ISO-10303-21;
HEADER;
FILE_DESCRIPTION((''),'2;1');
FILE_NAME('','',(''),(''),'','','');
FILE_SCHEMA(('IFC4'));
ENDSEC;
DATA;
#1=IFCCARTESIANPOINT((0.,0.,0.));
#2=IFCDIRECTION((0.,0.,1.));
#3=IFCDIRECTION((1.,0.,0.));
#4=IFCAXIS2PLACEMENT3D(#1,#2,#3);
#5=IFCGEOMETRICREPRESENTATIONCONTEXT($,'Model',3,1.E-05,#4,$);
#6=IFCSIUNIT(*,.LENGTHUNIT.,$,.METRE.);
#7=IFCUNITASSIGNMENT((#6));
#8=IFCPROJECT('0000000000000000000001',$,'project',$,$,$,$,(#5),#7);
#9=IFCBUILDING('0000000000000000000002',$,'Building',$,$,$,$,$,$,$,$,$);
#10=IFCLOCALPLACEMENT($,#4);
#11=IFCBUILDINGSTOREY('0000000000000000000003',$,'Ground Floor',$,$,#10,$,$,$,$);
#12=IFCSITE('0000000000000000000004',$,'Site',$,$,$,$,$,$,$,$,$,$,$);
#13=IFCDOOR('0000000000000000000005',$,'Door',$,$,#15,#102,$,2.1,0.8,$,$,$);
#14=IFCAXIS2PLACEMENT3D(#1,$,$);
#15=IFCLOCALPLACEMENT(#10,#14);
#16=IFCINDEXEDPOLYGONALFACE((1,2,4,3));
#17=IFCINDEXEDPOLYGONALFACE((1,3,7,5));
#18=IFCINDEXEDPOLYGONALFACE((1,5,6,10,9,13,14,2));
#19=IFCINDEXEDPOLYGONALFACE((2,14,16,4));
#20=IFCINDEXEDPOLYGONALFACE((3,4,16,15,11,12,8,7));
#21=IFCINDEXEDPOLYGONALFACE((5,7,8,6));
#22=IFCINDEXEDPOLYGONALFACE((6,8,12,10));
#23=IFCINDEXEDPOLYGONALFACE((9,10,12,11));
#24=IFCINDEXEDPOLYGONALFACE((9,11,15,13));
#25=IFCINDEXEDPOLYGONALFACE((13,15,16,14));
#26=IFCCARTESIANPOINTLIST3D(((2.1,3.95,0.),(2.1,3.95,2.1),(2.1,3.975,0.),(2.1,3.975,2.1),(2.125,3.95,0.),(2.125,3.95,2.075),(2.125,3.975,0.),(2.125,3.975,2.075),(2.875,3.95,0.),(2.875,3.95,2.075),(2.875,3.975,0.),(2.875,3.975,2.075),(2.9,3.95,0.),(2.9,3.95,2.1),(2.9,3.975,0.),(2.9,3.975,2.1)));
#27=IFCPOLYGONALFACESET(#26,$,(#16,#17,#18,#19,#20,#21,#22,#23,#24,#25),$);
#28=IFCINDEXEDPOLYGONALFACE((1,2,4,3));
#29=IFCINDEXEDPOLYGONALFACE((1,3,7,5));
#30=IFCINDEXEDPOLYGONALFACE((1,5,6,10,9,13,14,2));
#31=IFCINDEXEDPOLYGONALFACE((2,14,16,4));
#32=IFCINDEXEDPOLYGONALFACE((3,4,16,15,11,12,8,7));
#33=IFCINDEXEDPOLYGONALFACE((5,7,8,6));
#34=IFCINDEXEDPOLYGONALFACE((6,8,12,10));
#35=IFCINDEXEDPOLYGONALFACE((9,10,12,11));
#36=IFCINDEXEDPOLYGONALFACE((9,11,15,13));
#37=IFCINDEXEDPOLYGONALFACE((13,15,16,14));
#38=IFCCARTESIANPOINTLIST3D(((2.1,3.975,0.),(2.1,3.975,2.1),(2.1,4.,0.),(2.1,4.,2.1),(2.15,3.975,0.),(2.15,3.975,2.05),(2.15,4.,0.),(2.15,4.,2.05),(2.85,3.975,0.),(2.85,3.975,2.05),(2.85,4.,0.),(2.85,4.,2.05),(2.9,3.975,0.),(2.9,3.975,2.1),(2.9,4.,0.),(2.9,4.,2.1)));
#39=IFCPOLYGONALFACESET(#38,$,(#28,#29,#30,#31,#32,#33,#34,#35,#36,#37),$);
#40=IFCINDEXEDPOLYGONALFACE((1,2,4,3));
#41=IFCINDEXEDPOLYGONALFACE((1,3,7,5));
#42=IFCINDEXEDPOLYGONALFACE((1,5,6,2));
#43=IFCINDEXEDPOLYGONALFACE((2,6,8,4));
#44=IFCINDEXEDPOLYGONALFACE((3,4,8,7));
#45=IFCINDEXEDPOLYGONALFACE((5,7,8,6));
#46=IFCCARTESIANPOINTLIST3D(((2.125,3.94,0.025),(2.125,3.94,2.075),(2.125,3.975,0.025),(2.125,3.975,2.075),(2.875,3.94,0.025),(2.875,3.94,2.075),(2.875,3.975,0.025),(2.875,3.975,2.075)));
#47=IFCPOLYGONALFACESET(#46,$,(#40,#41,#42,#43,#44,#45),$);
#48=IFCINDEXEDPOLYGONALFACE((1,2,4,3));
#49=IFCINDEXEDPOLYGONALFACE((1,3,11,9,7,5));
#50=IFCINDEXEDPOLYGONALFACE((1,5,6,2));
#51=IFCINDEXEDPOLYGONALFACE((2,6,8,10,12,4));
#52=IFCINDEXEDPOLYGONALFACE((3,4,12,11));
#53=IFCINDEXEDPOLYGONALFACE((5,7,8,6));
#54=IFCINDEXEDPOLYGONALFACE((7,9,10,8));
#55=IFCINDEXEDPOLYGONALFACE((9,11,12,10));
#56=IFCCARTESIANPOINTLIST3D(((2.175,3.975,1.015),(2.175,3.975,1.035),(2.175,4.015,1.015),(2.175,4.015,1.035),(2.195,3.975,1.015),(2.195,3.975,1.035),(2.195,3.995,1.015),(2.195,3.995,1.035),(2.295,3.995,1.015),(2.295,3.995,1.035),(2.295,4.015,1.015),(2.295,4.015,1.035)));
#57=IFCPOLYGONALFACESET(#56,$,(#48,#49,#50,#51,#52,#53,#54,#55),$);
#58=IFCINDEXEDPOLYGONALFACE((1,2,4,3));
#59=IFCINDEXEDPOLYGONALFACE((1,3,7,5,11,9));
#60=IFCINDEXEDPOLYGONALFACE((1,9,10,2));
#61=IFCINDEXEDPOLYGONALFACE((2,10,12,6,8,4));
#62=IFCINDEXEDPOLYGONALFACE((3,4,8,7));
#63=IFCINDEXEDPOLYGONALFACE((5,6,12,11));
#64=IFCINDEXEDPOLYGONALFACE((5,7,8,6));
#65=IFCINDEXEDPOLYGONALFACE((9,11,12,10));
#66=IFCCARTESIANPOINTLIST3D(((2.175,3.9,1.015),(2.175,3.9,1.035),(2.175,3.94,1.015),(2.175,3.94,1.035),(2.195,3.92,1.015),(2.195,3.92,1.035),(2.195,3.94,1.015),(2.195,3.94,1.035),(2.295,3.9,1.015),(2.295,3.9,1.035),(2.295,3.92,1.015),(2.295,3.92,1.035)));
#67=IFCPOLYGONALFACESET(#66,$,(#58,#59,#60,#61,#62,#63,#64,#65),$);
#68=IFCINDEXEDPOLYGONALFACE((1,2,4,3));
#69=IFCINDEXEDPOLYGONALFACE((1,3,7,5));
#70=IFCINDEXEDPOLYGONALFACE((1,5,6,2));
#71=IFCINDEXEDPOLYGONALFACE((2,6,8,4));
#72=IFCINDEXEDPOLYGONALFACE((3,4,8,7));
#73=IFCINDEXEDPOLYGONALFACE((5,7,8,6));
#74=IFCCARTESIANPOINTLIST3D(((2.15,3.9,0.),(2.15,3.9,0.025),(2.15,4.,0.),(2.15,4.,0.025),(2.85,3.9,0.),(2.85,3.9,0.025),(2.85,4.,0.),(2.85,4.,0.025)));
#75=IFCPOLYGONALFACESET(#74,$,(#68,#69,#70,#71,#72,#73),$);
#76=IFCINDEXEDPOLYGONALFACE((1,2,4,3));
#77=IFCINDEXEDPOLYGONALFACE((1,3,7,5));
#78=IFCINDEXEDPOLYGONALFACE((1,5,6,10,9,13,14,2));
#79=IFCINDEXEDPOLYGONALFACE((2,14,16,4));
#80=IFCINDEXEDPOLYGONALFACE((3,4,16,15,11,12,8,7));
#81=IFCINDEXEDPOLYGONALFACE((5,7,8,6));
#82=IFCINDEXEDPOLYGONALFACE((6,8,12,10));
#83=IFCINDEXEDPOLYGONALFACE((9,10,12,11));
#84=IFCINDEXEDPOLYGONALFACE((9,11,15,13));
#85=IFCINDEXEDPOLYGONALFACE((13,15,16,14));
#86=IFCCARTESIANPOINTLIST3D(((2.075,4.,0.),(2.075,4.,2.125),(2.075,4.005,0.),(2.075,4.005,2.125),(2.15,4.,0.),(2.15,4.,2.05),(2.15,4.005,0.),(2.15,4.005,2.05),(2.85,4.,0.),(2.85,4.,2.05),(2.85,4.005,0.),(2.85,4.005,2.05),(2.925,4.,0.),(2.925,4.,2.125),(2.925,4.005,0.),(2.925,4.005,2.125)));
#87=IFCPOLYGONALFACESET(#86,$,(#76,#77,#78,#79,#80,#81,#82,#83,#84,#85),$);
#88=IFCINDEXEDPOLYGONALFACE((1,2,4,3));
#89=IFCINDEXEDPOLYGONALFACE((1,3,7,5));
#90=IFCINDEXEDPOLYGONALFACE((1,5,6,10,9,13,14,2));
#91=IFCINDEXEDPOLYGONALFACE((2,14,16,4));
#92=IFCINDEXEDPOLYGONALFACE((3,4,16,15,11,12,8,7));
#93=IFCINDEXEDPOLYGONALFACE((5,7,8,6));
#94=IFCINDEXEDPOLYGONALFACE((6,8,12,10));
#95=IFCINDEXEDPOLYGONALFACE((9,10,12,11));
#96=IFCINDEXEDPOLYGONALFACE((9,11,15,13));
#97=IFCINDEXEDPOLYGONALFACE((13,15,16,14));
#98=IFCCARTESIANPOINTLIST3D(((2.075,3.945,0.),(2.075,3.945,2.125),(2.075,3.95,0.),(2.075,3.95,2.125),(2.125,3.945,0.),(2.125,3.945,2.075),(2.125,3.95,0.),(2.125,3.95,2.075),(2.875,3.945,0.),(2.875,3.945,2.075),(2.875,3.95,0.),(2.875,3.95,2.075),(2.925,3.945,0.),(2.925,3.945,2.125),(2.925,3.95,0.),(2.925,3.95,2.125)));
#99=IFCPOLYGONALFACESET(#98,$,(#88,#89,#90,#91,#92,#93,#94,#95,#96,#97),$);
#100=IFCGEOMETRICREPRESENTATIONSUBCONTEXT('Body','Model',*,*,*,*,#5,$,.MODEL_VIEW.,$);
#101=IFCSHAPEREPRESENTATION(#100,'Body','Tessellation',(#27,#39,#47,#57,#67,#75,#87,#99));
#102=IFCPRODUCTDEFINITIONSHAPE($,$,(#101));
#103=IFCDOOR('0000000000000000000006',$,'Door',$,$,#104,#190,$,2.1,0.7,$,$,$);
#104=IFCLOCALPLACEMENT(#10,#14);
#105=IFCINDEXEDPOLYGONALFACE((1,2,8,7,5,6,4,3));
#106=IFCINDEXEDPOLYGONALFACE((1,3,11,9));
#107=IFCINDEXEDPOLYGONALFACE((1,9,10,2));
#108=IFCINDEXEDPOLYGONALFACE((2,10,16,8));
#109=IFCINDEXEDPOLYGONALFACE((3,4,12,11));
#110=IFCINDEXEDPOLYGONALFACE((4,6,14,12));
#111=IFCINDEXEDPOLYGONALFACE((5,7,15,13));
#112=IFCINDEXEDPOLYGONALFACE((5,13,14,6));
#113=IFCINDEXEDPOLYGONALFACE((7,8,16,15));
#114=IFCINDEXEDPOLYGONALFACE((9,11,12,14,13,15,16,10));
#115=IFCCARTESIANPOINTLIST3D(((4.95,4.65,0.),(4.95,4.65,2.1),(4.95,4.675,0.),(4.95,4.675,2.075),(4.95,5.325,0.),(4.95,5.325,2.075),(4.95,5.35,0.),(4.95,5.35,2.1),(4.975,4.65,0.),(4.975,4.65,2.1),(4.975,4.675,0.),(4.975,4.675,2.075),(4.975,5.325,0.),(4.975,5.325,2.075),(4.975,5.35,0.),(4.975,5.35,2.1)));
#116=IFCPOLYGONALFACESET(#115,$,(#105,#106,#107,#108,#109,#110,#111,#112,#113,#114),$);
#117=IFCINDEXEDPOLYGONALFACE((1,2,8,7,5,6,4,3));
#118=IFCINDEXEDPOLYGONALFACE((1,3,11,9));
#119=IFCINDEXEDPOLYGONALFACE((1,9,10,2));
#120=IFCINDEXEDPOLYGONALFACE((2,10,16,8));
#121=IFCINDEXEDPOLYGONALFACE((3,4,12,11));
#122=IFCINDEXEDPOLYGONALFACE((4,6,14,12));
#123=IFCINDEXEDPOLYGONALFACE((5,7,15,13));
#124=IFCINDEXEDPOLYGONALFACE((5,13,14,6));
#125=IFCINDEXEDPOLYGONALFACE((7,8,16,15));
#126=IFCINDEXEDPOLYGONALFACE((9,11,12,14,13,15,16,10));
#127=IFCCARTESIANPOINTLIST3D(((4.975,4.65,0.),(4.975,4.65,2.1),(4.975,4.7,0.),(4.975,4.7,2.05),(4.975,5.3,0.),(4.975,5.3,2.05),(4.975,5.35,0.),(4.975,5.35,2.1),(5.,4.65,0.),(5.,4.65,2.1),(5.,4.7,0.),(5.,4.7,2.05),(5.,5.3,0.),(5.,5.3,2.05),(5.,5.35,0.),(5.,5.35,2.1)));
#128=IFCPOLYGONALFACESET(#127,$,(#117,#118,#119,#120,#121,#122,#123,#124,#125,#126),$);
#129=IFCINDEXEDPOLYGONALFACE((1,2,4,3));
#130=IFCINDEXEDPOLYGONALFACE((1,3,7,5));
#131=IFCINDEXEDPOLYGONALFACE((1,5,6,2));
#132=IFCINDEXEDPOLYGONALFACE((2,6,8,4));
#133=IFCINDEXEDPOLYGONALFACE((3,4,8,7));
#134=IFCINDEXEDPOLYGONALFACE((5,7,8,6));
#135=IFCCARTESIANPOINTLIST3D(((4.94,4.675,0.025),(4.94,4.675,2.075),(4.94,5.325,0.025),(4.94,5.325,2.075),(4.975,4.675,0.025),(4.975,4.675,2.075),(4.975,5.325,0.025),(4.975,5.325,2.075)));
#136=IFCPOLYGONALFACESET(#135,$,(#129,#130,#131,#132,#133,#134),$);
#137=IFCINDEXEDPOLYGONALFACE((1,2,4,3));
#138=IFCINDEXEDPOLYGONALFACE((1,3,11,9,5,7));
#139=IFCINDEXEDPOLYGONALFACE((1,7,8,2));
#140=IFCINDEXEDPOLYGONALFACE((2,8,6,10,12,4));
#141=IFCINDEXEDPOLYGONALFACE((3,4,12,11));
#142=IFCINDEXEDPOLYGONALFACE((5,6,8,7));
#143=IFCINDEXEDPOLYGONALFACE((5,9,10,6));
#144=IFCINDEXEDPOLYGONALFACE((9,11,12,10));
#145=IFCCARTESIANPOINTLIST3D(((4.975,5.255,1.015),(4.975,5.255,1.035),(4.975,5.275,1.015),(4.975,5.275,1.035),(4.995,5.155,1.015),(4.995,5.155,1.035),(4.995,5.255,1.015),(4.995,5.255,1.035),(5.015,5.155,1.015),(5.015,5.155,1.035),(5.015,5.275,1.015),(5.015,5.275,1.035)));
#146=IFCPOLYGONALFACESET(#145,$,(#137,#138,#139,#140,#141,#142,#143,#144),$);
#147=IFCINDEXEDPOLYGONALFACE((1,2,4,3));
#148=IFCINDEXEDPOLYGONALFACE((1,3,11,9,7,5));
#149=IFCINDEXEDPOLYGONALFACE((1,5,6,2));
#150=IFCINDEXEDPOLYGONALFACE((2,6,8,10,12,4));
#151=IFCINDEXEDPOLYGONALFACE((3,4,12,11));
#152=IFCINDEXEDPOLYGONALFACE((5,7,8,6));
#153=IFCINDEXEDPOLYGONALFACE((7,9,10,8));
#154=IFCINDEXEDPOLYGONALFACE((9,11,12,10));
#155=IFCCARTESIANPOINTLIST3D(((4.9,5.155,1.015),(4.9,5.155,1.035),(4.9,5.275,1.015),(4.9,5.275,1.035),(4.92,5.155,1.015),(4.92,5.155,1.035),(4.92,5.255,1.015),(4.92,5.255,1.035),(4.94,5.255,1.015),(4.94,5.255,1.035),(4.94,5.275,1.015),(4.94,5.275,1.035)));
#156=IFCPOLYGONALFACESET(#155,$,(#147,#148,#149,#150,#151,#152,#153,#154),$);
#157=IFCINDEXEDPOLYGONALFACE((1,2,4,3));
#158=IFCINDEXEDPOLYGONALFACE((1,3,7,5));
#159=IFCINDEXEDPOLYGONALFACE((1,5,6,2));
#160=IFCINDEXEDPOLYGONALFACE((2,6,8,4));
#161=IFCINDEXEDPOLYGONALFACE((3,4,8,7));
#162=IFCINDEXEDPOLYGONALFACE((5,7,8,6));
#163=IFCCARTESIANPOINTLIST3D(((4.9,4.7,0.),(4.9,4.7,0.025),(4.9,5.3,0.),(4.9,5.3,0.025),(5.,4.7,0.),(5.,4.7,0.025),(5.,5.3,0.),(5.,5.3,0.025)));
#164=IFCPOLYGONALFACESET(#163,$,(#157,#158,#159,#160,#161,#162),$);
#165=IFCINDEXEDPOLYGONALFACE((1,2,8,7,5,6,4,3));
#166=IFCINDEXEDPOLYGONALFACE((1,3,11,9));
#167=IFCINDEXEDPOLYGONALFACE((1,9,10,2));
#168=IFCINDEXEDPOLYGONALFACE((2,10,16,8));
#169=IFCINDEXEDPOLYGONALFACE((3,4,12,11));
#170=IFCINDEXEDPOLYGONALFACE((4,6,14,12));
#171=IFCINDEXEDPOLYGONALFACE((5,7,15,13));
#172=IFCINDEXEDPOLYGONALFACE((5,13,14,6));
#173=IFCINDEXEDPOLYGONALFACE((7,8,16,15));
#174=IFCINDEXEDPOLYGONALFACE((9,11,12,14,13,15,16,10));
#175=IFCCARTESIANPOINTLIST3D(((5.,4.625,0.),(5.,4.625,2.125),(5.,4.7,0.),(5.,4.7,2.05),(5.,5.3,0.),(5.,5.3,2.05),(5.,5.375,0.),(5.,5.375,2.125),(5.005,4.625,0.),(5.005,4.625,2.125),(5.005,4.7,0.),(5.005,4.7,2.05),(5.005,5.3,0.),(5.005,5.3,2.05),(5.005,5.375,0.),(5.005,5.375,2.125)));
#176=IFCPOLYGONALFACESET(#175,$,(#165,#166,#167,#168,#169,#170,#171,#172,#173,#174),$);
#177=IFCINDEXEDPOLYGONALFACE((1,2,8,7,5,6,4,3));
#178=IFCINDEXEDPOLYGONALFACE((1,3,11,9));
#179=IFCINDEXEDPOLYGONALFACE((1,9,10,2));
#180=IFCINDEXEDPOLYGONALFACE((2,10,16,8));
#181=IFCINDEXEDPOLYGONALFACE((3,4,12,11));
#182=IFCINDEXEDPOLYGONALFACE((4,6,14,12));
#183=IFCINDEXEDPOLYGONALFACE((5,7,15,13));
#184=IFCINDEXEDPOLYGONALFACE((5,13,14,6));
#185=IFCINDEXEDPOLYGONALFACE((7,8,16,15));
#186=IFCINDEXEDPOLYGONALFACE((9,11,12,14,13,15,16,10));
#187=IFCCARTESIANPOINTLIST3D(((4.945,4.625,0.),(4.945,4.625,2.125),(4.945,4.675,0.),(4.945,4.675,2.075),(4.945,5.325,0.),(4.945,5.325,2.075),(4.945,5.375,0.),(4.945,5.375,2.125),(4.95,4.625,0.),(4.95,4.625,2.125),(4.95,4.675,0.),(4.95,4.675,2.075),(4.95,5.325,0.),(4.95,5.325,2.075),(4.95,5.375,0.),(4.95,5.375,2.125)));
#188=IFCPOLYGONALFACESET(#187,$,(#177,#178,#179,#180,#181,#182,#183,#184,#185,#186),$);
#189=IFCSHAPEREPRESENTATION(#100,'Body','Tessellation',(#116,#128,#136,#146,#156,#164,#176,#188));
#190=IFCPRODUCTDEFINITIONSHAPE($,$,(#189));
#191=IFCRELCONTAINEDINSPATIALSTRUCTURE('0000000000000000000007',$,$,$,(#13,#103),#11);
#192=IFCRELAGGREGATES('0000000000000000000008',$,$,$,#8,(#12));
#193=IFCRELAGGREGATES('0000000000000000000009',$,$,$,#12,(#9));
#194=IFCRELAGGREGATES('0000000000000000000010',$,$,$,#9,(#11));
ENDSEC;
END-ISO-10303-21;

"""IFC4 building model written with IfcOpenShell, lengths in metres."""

from ifc_helpers import new_model, si_unit, frame, origin_with_axes, place, context, subcontext, project, spatial, line, indexed_curve, outline, extrude, element, save


model = new_model("IFC4")

# Units and contexts
model_context = context("Model", 3, precision=1e-05, world=origin_with_axes())
body_context = subcontext(model_context, "Body", "Model", "MODEL_VIEW")
ifc_project = project(units=[si_unit("LENGTHUNIT", "METRE")], contexts=[model_context])

# Site, building, storey
site = spatial("IfcSite", under=ifc_project, Name="Site")
building = spatial("IfcBuilding", under=site, Name="Building")
storey_placement = place(None, origin_with_axes())
storey = spatial("IfcBuildingStorey", under=building, at=storey_placement, Name="Ground Floor")

# Doors
door_1_placement = place(storey_placement, frame((2.9, 4.0, 0.0), z_axis=(0.0, 0.0, 1.0), x_axis=(-1.0, 0.0, 0.0)))
element("IfcDoor", 1, at=door_1_placement, inside=storey, Name="Door", OverallHeight=2.1, OverallWidth=0.8, context=body_context, shape_type="SweptSolid", body=[
    extrude(outline(indexed_curve([(0.0, 0.0), (0.0, 2.1), (0.8, 2.1), (0.8, 0.0), (0.775, 0.0), (0.775, 2.075), (0.025, 2.075), (0.025, 0.0)], segments=[line(1, 2, 3, 4, 5, 6, 7, 8, 1)])), frame((0.0, 0.025, 0.0), z_axis=(0.0, -1.0, 0.0), x_axis=(1.0, 0.0, 0.0)), (0.0, 0.0, -1.0), 0.025),
    extrude(outline(indexed_curve([(0.0, 0.0), (0.0, 2.1), (0.8, 2.1), (0.8, 0.0), (0.75, 0.0), (0.75, 2.05), (0.05, 2.05), (0.05, 0.0)], segments=[line(1, 2, 3, 4, 5, 6, 7, 8, 1)])), frame((0.0, 0.0, 0.0), z_axis=(0.0, -1.0, 0.0), x_axis=(1.0, 0.0, 0.0)), (0.0, 0.0, -1.0), 0.025),
    extrude(outline(indexed_curve([(0.0, 0.0), (0.75, 0.0), (0.75, 0.035), (0.0, 0.035)], segments=[line(1, 2, 3, 4, 1)])), frame((0.025, 0.025, 0.025), z_axis=(0.0, 0.0, 1.0), x_axis=(1.0, 0.0, 0.0)), (0.0, 0.0, 1.0), 2.05),
    extrude(outline(indexed_curve([(0.0, 0.0), (0.0, -0.04), (-0.12, -0.04), (-0.12, -0.02), (-0.02, -0.02), (-0.02, 0.0)], segments=[line(1, 2, 3, 4, 5, 6, 1)])), frame((0.725, 0.025, 1.015), z_axis=(0.0, 0.0, 1.0), x_axis=(1.0, 0.0, 0.0)), (0.0, 0.0, 1.0), 0.02),
    extrude(outline(indexed_curve([(0.0, 0.0), (0.0, 0.04), (-0.12, 0.04), (-0.12, 0.02), (-0.02, 0.02), (-0.02, 0.0)], segments=[line(1, 2, 3, 4, 5, 6, 1)])), frame((0.725, 0.06, 1.015), z_axis=(0.0, 0.0, 1.0), x_axis=(1.0, 0.0, 0.0)), (0.0, 0.0, 1.0), 0.02),
    extrude(outline(indexed_curve([(0.0, 0.0), (0.7, 0.0), (0.7, 0.1), (0.0, 0.1)], segments=[line(1, 2, 3, 4, 1)])), frame((0.05, 0.0, 0.0), z_axis=(0.0, 0.0, 1.0), x_axis=(1.0, 0.0, 0.0)), (0.0, 0.0, 1.0), 0.025),
    extrude(outline(indexed_curve([(0.0, 0.0), (0.0, 2.125), (0.85, 2.125), (0.85, 0.0), (0.775, 0.0), (0.775, 2.05), (0.075, 2.05), (0.075, 0.0)], segments=[line(1, 2, 3, 4, 5, 6, 7, 8, 1)])), frame((-0.025, -0.005, 0.0), z_axis=(0.0, -1.0, 0.0), x_axis=(1.0, 0.0, 0.0)), (0.0, 0.0, -1.0), 0.005),
    extrude(outline(indexed_curve([(0.0, 0.0), (0.0, 2.125), (0.85, 2.125), (0.85, 0.0), (0.8, 0.0), (0.8, 2.075), (0.05, 2.075), (0.05, 0.0)], segments=[line(1, 2, 3, 4, 5, 6, 7, 8, 1)])), frame((-0.025, 0.05, 0.0), z_axis=(0.0, -1.0, 0.0), x_axis=(1.0, 0.0, 0.0)), (0.0, 0.0, -1.0), 0.005),
])
door_2_placement = place(storey_placement, frame((5.0, 4.65, 0.0), z_axis=(0.0, 0.0, 1.0), x_axis=(0.0, 1.0, 0.0)))
element("IfcDoor", 2, at=door_2_placement, inside=storey, Name="Door", OverallHeight=2.1, OverallWidth=0.7, context=body_context, shape_type="SweptSolid", body=[
    extrude(outline(indexed_curve([(0.0, 0.0), (0.0, 2.1), (0.7, 2.1), (0.7, 0.0), (0.675, 0.0), (0.675, 2.075), (0.025, 2.075), (0.025, 0.0)], segments=[line(1, 2, 3, 4, 5, 6, 7, 8, 1)])), frame((0.0, 0.025, 0.0), z_axis=(0.0, -1.0, 0.0), x_axis=(1.0, 0.0, 0.0)), (0.0, 0.0, -1.0), 0.025),
    extrude(outline(indexed_curve([(0.0, 0.0), (0.0, 2.1), (0.7, 2.1), (0.7, 0.0), (0.65, 0.0), (0.65, 2.05), (0.05, 2.05), (0.05, 0.0)], segments=[line(1, 2, 3, 4, 5, 6, 7, 8, 1)])), frame((0.0, 0.0, 0.0), z_axis=(0.0, -1.0, 0.0), x_axis=(1.0, 0.0, 0.0)), (0.0, 0.0, -1.0), 0.025),
    extrude(outline(indexed_curve([(0.0, 0.0), (0.65, 0.0), (0.65, 0.035), (0.0, 0.035)], segments=[line(1, 2, 3, 4, 1)])), frame((0.025, 0.025, 0.025), z_axis=(0.0, 0.0, 1.0), x_axis=(1.0, 0.0, 0.0)), (0.0, 0.0, 1.0), 2.05),
    extrude(outline(indexed_curve([(0.0, 0.0), (0.0, -0.04), (-0.12, -0.04), (-0.12, -0.02), (-0.02, -0.02), (-0.02, 0.0)], segments=[line(1, 2, 3, 4, 5, 6, 1)])), frame((0.625, 0.025, 1.015), z_axis=(0.0, 0.0, 1.0), x_axis=(1.0, 0.0, 0.0)), (0.0, 0.0, 1.0), 0.02),
    extrude(outline(indexed_curve([(0.0, 0.0), (0.0, 0.04), (-0.12, 0.04), (-0.12, 0.02), (-0.02, 0.02), (-0.02, 0.0)], segments=[line(1, 2, 3, 4, 5, 6, 1)])), frame((0.625, 0.06, 1.015), z_axis=(0.0, 0.0, 1.0), x_axis=(1.0, 0.0, 0.0)), (0.0, 0.0, 1.0), 0.02),
    extrude(outline(indexed_curve([(0.0, 0.0), (0.6, 0.0), (0.6, 0.1), (0.0, 0.1)], segments=[line(1, 2, 3, 4, 1)])), frame((0.05, 0.0, 0.0), z_axis=(0.0, 0.0, 1.0), x_axis=(1.0, 0.0, 0.0)), (0.0, 0.0, 1.0), 0.025),
    extrude(outline(indexed_curve([(0.0, 0.0), (0.0, 2.125), (0.75, 2.125), (0.75, 0.0), (0.675, 0.0), (0.675, 2.05), (0.075, 2.05), (0.075, 0.0)], segments=[line(1, 2, 3, 4, 5, 6, 7, 8, 1)])), frame((-0.025, -0.005, 0.0), z_axis=(0.0, -1.0, 0.0), x_axis=(1.0, 0.0, 0.0)), (0.0, 0.0, -1.0), 0.005),
    extrude(outline(indexed_curve([(0.0, 0.0), (0.0, 2.125), (0.75, 2.125), (0.75, 0.0), (0.7, 0.0), (0.7, 2.075), (0.05, 2.075), (0.05, 0.0)], segments=[line(1, 2, 3, 4, 5, 6, 7, 8, 1)])), frame((-0.025, 0.05, 0.0), z_axis=(0.0, -1.0, 0.0), x_axis=(1.0, 0.0, 0.0)), (0.0, 0.0, -1.0), 0.005),
])

save(model, "model.ifc")
